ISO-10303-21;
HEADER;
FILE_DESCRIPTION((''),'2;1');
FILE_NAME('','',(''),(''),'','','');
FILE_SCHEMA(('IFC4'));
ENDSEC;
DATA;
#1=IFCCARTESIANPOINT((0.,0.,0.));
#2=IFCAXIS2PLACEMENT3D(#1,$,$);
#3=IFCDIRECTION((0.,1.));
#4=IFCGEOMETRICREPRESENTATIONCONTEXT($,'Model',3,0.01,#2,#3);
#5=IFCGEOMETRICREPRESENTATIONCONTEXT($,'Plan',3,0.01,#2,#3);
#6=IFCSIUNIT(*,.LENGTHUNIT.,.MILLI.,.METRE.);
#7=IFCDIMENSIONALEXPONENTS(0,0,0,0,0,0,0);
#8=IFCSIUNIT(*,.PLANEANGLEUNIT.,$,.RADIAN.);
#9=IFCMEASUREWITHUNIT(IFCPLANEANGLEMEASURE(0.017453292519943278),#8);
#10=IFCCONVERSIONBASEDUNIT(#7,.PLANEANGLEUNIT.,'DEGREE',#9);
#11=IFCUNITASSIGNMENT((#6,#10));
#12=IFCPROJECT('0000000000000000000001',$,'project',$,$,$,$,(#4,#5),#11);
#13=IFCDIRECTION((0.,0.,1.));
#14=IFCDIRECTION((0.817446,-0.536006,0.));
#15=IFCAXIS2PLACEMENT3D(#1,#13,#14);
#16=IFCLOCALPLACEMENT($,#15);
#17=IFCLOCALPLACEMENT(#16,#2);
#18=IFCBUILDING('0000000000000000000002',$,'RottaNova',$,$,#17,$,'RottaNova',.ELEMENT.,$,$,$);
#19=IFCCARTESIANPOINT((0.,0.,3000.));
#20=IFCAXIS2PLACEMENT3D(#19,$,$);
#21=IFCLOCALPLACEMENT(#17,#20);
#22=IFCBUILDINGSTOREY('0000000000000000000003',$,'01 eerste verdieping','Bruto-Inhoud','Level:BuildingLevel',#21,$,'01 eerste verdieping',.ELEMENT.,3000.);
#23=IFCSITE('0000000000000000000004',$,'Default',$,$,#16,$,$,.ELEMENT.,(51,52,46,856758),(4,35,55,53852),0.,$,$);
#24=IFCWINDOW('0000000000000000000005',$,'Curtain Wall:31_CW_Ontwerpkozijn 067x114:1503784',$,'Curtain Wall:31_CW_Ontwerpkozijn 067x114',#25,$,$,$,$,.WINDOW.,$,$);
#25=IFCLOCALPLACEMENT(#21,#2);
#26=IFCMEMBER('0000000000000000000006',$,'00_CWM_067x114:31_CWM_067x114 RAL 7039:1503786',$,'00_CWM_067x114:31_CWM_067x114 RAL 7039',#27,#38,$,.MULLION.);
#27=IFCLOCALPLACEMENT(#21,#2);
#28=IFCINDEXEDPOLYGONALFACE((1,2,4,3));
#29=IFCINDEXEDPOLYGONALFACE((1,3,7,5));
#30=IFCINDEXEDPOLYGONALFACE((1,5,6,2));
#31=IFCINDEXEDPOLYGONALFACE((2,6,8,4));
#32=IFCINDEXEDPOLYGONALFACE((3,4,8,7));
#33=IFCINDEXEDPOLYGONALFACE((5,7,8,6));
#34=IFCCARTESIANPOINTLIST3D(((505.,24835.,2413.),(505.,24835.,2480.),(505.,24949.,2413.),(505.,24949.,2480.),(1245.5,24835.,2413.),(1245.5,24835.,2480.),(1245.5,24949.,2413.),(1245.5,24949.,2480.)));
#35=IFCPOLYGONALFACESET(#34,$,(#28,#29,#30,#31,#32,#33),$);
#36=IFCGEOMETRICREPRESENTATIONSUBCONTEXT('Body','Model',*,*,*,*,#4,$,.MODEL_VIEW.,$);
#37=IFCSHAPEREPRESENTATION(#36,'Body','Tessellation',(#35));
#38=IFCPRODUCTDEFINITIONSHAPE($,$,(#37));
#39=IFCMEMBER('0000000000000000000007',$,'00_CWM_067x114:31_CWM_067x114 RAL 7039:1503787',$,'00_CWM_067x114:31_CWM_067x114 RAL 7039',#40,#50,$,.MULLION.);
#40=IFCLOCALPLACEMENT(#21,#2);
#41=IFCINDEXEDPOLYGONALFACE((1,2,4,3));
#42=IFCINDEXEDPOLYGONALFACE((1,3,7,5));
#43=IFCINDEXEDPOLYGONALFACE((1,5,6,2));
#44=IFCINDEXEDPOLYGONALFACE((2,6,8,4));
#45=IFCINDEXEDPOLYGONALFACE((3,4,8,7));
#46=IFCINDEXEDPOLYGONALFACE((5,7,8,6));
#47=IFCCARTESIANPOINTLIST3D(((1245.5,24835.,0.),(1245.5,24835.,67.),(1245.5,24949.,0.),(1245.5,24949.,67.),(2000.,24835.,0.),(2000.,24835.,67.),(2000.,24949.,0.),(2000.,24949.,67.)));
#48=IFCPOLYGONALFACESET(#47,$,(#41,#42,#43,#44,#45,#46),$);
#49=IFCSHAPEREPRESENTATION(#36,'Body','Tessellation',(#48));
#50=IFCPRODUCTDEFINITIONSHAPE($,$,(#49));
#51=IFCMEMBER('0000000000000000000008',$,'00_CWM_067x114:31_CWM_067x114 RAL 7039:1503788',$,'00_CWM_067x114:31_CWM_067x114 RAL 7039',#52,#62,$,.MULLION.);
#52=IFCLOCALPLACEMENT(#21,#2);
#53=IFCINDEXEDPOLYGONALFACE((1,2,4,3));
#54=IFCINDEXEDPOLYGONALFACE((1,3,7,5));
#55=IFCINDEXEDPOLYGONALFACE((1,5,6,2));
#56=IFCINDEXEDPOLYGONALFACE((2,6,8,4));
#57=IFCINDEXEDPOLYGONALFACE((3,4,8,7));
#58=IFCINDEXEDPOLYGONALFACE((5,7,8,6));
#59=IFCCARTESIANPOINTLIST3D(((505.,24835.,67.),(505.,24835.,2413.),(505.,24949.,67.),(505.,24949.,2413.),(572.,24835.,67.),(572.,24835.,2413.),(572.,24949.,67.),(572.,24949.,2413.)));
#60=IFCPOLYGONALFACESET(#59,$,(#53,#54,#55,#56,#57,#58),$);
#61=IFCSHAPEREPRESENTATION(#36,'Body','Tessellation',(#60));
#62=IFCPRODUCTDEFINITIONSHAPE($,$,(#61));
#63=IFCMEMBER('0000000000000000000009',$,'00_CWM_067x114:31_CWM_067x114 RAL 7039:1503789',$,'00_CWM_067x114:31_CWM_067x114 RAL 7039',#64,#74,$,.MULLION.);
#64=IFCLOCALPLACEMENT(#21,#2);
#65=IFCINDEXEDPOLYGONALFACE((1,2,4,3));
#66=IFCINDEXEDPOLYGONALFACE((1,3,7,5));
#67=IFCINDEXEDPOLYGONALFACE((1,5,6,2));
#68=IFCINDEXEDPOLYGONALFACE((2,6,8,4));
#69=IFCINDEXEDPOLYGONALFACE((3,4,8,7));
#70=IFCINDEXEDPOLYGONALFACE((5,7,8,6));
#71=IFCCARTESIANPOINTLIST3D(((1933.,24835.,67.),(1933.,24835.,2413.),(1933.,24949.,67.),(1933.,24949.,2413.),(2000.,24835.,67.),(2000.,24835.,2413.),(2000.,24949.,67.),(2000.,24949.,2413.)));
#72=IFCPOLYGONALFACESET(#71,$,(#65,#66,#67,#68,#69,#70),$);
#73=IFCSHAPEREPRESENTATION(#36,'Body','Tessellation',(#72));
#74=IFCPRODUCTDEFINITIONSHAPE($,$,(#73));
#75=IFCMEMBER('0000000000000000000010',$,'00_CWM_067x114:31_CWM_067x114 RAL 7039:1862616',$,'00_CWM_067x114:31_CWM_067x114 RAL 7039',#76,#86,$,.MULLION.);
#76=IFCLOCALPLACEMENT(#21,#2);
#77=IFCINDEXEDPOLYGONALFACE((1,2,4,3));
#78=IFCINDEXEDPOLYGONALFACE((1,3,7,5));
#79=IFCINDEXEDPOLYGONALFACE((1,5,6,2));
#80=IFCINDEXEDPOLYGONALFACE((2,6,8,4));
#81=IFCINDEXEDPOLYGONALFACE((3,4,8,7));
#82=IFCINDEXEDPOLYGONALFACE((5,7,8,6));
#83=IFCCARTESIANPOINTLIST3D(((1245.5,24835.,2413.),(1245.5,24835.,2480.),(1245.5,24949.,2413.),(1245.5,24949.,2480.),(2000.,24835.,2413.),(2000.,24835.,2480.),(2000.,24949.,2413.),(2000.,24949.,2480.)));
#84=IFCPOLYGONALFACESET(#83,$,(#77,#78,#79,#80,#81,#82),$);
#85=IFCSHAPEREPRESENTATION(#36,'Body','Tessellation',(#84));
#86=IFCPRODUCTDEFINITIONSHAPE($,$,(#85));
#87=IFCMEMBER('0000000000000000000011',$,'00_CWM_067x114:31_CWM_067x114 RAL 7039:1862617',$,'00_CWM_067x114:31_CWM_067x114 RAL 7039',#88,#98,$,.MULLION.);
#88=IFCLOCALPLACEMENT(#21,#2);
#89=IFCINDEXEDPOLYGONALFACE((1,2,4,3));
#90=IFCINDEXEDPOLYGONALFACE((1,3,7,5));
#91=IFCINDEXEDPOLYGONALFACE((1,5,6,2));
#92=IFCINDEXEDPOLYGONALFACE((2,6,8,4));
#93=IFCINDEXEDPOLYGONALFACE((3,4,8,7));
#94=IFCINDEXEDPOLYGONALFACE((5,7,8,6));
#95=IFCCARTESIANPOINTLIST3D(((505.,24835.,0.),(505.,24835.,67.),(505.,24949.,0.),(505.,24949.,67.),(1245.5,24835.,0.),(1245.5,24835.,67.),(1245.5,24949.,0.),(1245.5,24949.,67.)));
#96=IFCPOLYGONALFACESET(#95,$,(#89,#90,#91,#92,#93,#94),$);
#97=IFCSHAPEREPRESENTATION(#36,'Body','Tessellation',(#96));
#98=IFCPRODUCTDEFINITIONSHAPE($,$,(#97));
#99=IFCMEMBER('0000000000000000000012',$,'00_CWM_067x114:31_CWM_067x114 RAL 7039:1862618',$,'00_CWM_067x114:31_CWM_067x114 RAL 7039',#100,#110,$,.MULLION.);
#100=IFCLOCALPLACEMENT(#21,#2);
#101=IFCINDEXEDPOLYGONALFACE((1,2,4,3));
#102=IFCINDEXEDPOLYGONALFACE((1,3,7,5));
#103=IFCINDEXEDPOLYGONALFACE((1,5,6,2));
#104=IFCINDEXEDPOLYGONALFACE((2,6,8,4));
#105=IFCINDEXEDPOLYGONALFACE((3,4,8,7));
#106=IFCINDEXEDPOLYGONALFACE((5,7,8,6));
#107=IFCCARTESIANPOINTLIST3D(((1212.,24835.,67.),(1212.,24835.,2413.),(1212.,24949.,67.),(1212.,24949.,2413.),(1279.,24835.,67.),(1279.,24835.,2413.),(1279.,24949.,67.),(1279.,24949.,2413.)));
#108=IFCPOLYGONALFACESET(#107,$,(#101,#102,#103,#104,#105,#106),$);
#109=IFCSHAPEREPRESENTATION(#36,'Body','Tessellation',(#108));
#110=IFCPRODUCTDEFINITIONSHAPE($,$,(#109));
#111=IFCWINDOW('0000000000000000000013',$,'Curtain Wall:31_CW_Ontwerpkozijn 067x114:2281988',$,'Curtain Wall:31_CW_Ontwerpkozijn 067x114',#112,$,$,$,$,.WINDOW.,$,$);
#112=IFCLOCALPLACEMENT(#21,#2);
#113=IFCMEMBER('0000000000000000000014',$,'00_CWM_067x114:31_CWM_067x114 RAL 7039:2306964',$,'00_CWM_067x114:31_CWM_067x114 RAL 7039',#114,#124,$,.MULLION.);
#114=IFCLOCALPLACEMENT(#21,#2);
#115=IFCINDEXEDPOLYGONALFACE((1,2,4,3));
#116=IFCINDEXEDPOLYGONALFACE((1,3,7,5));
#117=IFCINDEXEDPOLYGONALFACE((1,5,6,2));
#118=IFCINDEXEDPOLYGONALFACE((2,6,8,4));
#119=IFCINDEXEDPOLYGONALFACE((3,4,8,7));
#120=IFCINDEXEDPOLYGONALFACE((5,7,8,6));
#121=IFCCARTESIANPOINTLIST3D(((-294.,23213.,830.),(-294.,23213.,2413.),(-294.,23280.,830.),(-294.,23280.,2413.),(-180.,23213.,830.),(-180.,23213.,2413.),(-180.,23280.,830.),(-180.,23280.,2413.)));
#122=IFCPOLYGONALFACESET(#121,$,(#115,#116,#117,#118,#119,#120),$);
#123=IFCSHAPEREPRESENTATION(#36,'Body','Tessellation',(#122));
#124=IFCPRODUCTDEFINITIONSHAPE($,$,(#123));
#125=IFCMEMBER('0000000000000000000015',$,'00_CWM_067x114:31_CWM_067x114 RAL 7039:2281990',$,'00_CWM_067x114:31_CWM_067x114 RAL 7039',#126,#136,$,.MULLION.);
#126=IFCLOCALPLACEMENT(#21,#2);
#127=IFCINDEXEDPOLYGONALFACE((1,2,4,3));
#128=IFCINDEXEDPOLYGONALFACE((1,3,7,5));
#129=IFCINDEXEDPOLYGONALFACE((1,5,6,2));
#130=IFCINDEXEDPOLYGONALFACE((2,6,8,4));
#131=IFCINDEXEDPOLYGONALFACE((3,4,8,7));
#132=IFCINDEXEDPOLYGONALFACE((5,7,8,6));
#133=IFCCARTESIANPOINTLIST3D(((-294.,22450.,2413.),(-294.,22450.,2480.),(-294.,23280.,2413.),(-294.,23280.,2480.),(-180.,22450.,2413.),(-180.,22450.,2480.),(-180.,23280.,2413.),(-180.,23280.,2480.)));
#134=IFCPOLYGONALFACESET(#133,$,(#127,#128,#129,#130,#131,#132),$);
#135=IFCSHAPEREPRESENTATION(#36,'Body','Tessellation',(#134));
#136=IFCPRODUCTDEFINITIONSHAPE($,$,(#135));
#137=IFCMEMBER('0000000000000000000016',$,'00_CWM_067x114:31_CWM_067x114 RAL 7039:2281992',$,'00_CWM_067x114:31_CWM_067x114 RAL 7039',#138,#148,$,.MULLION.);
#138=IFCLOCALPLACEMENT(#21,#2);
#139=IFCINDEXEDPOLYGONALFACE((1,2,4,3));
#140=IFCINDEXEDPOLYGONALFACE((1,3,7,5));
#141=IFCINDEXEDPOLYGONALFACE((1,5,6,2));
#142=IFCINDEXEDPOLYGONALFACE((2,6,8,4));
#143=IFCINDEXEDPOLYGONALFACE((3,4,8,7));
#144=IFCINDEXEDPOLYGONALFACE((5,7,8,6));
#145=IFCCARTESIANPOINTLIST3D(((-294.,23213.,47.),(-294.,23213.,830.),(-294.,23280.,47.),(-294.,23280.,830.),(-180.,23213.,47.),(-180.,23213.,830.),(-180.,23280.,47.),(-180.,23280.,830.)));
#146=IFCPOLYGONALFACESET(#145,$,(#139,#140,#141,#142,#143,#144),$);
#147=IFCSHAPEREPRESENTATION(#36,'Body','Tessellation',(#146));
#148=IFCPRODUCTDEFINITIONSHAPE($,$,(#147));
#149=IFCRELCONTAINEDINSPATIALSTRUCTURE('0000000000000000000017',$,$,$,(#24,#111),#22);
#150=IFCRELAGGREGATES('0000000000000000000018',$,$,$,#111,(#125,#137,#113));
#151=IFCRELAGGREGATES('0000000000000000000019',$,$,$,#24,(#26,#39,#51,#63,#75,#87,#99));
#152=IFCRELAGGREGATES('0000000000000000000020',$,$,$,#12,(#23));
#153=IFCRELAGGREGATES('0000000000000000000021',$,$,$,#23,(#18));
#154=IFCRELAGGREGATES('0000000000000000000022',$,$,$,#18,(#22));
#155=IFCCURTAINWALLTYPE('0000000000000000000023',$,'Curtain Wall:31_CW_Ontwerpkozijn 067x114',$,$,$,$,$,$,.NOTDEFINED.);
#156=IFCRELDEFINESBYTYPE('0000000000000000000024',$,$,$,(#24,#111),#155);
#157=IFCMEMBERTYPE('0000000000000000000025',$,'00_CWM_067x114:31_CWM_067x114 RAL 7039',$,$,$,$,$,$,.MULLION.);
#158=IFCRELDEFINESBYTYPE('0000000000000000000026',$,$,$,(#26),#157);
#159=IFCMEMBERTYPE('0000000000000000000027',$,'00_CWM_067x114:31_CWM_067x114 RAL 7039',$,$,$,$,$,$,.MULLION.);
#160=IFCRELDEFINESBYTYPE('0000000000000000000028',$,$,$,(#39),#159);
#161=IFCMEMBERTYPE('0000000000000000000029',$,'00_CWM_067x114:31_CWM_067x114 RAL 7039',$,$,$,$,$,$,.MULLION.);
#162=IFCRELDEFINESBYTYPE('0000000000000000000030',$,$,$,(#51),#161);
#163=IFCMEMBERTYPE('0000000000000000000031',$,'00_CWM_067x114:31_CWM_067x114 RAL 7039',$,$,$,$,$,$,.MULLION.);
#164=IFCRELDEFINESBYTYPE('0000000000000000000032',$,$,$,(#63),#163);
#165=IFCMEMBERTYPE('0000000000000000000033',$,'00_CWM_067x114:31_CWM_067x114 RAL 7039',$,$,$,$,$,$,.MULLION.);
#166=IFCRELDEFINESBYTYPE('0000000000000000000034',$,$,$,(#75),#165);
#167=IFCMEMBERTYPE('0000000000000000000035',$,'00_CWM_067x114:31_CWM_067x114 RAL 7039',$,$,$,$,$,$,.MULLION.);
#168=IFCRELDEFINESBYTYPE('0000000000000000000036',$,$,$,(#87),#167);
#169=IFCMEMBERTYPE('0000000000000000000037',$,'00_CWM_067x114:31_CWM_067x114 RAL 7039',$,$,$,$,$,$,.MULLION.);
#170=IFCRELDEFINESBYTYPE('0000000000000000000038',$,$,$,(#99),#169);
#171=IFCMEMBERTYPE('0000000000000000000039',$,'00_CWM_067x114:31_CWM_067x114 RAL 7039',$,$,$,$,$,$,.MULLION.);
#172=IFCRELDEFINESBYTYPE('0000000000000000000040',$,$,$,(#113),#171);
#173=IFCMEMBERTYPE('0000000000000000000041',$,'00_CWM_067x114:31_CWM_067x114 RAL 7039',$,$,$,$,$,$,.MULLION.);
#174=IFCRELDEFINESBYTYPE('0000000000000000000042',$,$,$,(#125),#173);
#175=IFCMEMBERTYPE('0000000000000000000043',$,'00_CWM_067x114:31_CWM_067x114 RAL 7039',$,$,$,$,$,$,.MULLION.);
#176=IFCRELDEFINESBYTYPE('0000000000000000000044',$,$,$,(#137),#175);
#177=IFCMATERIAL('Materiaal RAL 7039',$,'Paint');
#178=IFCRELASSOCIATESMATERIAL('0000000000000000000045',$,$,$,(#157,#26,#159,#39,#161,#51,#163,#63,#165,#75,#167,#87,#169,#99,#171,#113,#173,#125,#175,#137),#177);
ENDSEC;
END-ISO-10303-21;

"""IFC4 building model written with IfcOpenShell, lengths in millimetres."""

from ifc_helpers import new_model, entity, si_unit, converted_unit, direction, frame, origin, place, context, subcontext, project, spatial, indexed_curve, outline, extrude, source, transform, mapped, material, type_object, type_shapes, element, aggregate, save


model = new_model("IFC4")

# Units and contexts
model_context = context("Model", 3, precision=0.01, world=origin(), true_north=direction((0.0, 1.0)))
plan_context = context("Plan", 3, precision=0.01, world=origin(), true_north=direction((0.0, 1.0)))
body_context = subcontext(model_context, "Body", "Model", "MODEL_VIEW")
ifc_project = project(units=[si_unit("LENGTHUNIT", "METRE", prefix="MILLI"), converted_unit("PLANEANGLEUNIT", "DEGREE", entity("IfcPlaneAngleMeasure", 0.017453292519943278), si_unit("PLANEANGLEUNIT", "RADIAN"), dimensions=[0, 0, 0, 0, 0, 0, 0])], contexts=[model_context, plan_context])

# Site, building, storey
site_placement = place(None, frame((0.0, 0.0, 0.0), z_axis=(0.0, 0.0, 1.0), x_axis=(0.817446, -0.536006, 0.0)))
site = spatial("IfcSite", under=ifc_project, at=site_placement, Name="Default", CompositionType="ELEMENT", RefLatitude=(51, 52, 46, 856758), RefLongitude=(4, 35, 55, 53852), RefElevation=0.0)
building_placement = place(site_placement, origin())
building = spatial("IfcBuilding", under=site, at=building_placement, Name="RottaNova", LongName="RottaNova", CompositionType="ELEMENT")
storey_placement = place(building_placement, frame((0.0, 0.0, 3000.0)))
storey = spatial("IfcBuildingStorey", under=building, at=storey_placement, Name="01 eerste verdieping", Description="Bruto-Inhoud", ObjectType="Level:BuildingLevel", LongName="01 eerste verdieping", CompositionType="ELEMENT", Elevation=3000.0)

# Windows, members
curtain_wall_type = type_object("IfcCurtainWallType", Name="Curtain Wall:31_CW_Ontwerpkozijn 067x114", PredefinedType="NOTDEFINED")
window_1_placement = place(storey_placement, frame((0.0, 0.0, -3000.0)))
window_1 = element("IfcWindow", 1, at=window_1_placement, inside=storey, type_object=curtain_wall_type, Name="Curtain Wall:31_CW_Ontwerpkozijn 067x114:1503784", ObjectType="Curtain Wall:31_CW_Ontwerpkozijn 067x114", PredefinedType="WINDOW")
ifc_material_1 = material(Name="Materiaal RAL 7039", Category="Paint")
member_type_1 = type_object("IfcMemberType", Name="00_CWM_067x114:31_CWM_067x114 RAL 7039", PredefinedType="MULLION", material=ifc_material_1)
shared_shape_1 = source(origin(), body_context, "Body", "SweptSolid", [
    extrude(outline(indexed_curve([(-33.5, -57.0), (33.5, -57.0), (33.5, 57.0), (-33.5, 57.0), (-33.5, -57.0)], self_intersect=False)), frame((-33.5, 57.0, -740.5), z_axis=(0.0, 0.0, 1.0), x_axis=(-1.0, 0.0, 0.0)), (0.0, 0.0, 1.0), 740.5),
])
type_shapes(member_type_1, [shared_shape_1])
member_1_placement = place(window_1_placement, frame((505.0, 24835.0, 5480.0), z_axis=(-1.0, 0.0, 0.0), x_axis=(0.0, 0.0, 1.0)))
member_1 = element("IfcMember", 2, at=member_1_placement, type_object=member_type_1, material=ifc_material_1, Name="00_CWM_067x114:31_CWM_067x114 RAL 7039:1503786", ObjectType="00_CWM_067x114:31_CWM_067x114 RAL 7039", PredefinedType="MULLION", context=body_context, shape_type="MappedRepresentation", body=[
    mapped(shared_shape_1, transform((0.0, 0.0, 0.0), scale=1.0)),
])
member_type_2 = type_object("IfcMemberType", Name="00_CWM_067x114:31_CWM_067x114 RAL 7039", PredefinedType="MULLION", material=ifc_material_1)
shared_shape_2 = source(origin(), body_context, "Body", "SweptSolid", [
    extrude(outline(indexed_curve([(-33.5, -57.0), (33.5, -57.0), (33.5, 57.0), (-33.5, 57.0), (-33.5, -57.0)], self_intersect=False)), frame((-33.5, 57.0, -754.5), z_axis=(0.0, 0.0, 1.0), x_axis=(-1.0, 0.0, 0.0)), (0.0, 0.0, 1.0), 754.5),
])
type_shapes(member_type_2, [shared_shape_2])
member_2_placement = place(window_1_placement, frame((2000.0, 24835.0, 3000.0), z_axis=(1.0, 0.0, 0.0), x_axis=(0.0, 0.0, -1.0)))
member_2 = element("IfcMember", 3, at=member_2_placement, type_object=member_type_2, material=ifc_material_1, Name="00_CWM_067x114:31_CWM_067x114 RAL 7039:1503787", ObjectType="00_CWM_067x114:31_CWM_067x114 RAL 7039", PredefinedType="MULLION", context=body_context, shape_type="MappedRepresentation", body=[
    mapped(shared_shape_2, transform((0.0, 0.0, 0.0), scale=1.0)),
])
member_type_3 = type_object("IfcMemberType", Name="00_CWM_067x114:31_CWM_067x114 RAL 7039", PredefinedType="MULLION", material=ifc_material_1)
shared_shape_3 = source(origin(), body_context, "Body", "SweptSolid", [
    extrude(outline(indexed_curve([(-33.5, -57.0), (33.5, -57.0), (33.5, 57.0), (-33.5, 57.0), (-33.5, -57.0)], self_intersect=False)), frame((-33.5, 57.0, -2346.0), z_axis=(0.0, 0.0, 1.0), x_axis=(-1.0, 0.0, 0.0)), (0.0, 0.0, 1.0), 2346.0),
])
type_shapes(member_type_3, [shared_shape_3])
member_3_placement = place(window_1_placement, frame((505.0, 24835.0, 3067.0), z_axis=(0.0, 0.0, -1.0), x_axis=(-1.0, 0.0, 0.0)))
member_3 = element("IfcMember", 4, at=member_3_placement, type_object=member_type_3, material=ifc_material_1, Name="00_CWM_067x114:31_CWM_067x114 RAL 7039:1503788", ObjectType="00_CWM_067x114:31_CWM_067x114 RAL 7039", PredefinedType="MULLION", context=body_context, shape_type="MappedRepresentation", body=[
    mapped(shared_shape_3, transform((0.0, 0.0, 0.0), scale=1.0)),
])
member_type_4 = type_object("IfcMemberType", Name="00_CWM_067x114:31_CWM_067x114 RAL 7039", PredefinedType="MULLION", material=ifc_material_1)
shared_shape_4 = source(origin(), body_context, "Body", "SweptSolid", [
    extrude(outline(indexed_curve([(-33.5, -57.0), (33.5, -57.0), (33.5, 57.0), (-33.5, 57.0), (-33.5, -57.0)], self_intersect=False)), frame((-33.5, 57.0, -2346.0), z_axis=(0.0, 0.0, 1.0), x_axis=(-1.0, 0.0, 0.0)), (0.0, 0.0, 1.0), 2346.0),
])
type_shapes(member_type_4, [shared_shape_4])
member_4_placement = place(window_1_placement, frame((2000.0, 24835.0, 5413.0)))
member_4 = element("IfcMember", 5, at=member_4_placement, type_object=member_type_4, material=ifc_material_1, Name="00_CWM_067x114:31_CWM_067x114 RAL 7039:1503789", ObjectType="00_CWM_067x114:31_CWM_067x114 RAL 7039", PredefinedType="MULLION", context=body_context, shape_type="MappedRepresentation", body=[
    mapped(shared_shape_4, transform((0.0, 0.0, 0.0), scale=1.0)),
])
member_type_5 = type_object("IfcMemberType", Name="00_CWM_067x114:31_CWM_067x114 RAL 7039", PredefinedType="MULLION", material=ifc_material_1)
shared_shape_5 = source(origin(), body_context, "Body", "SweptSolid", [
    extrude(outline(indexed_curve([(-33.5, -57.0), (33.5, -57.0), (33.5, 57.0), (-33.5, 57.0), (-33.5, -57.0)], self_intersect=False)), frame((-33.5, 57.0, -754.5), z_axis=(0.0, 0.0, 1.0), x_axis=(-1.0, 0.0, 0.0)), (0.0, 0.0, 1.0), 754.5),
])
type_shapes(member_type_5, [shared_shape_5])
member_5_placement = place(window_1_placement, frame((1245.5, 24835.0, 5480.0), z_axis=(-1.0, 0.0, 0.0), x_axis=(0.0, 0.0, 1.0)))
member_5 = element("IfcMember", 6, at=member_5_placement, type_object=member_type_5, material=ifc_material_1, Name="00_CWM_067x114:31_CWM_067x114 RAL 7039:1862616", ObjectType="00_CWM_067x114:31_CWM_067x114 RAL 7039", PredefinedType="MULLION", context=body_context, shape_type="MappedRepresentation", body=[
    mapped(shared_shape_5, transform((0.0, 0.0, 0.0), scale=1.0)),
])
member_type_6 = type_object("IfcMemberType", Name="00_CWM_067x114:31_CWM_067x114 RAL 7039", PredefinedType="MULLION", material=ifc_material_1)
shared_shape_6 = source(origin(), body_context, "Body", "SweptSolid", [
    extrude(outline(indexed_curve([(-33.5, -57.0), (33.5, -57.0), (33.5, 57.0), (-33.5, 57.0), (-33.5, -57.0)], self_intersect=False)), frame((-33.5, 57.0, -740.5), z_axis=(0.0, 0.0, 1.0), x_axis=(-1.0, 0.0, 0.0)), (0.0, 0.0, 1.0), 740.5),
])
type_shapes(member_type_6, [shared_shape_6])
member_6_placement = place(window_1_placement, frame((1245.5, 24835.0, 3000.0), z_axis=(1.0, 0.0, 0.0), x_axis=(0.0, 0.0, -1.0)))
member_6 = element("IfcMember", 7, at=member_6_placement, type_object=member_type_6, material=ifc_material_1, Name="00_CWM_067x114:31_CWM_067x114 RAL 7039:1862617", ObjectType="00_CWM_067x114:31_CWM_067x114 RAL 7039", PredefinedType="MULLION", context=body_context, shape_type="MappedRepresentation", body=[
    mapped(shared_shape_6, transform((0.0, 0.0, 0.0), scale=1.0)),
])
member_type_7 = type_object("IfcMemberType", Name="00_CWM_067x114:31_CWM_067x114 RAL 7039", PredefinedType="MULLION", material=ifc_material_1)
shared_shape_7 = source(origin(), body_context, "Body", "SweptSolid", [
    extrude(outline(indexed_curve([(-33.5, -57.0), (33.5, -57.0), (33.5, 57.0), (-33.5, 57.0), (-33.5, -57.0)], self_intersect=False)), frame((0.0, 57.0, -2346.0), z_axis=(0.0, 0.0, 1.0), x_axis=(-1.0, 0.0, 0.0)), (0.0, 0.0, 1.0), 2346.0),
])
type_shapes(member_type_7, [shared_shape_7])
member_7_placement = place(window_1_placement, frame((1245.5, 24835.0, 3067.0), z_axis=(0.0, 0.0, -1.0), x_axis=(-1.0, 0.0, 0.0)))
member_7 = element("IfcMember", 8, at=member_7_placement, type_object=member_type_7, material=ifc_material_1, Name="00_CWM_067x114:31_CWM_067x114 RAL 7039:1862618", ObjectType="00_CWM_067x114:31_CWM_067x114 RAL 7039", PredefinedType="MULLION", context=body_context, shape_type="MappedRepresentation", body=[
    mapped(shared_shape_7, transform((0.0, 0.0, 0.0), scale=1.0)),
])
window_2_placement = place(storey_placement, frame((0.0, 0.0, -3000.0)))
window_2 = element("IfcWindow", 9, at=window_2_placement, inside=storey, type_object=curtain_wall_type, Name="Curtain Wall:31_CW_Ontwerpkozijn 067x114:2281988", ObjectType="Curtain Wall:31_CW_Ontwerpkozijn 067x114", PredefinedType="WINDOW")
member_type_8 = type_object("IfcMemberType", Name="00_CWM_067x114:31_CWM_067x114 RAL 7039", PredefinedType="MULLION", material=ifc_material_1)
shared_shape_8 = source(origin(), body_context, "Body", "SweptSolid", [
    extrude(outline(indexed_curve([(-33.5, -57.0), (33.5, -57.0), (33.5, 57.0), (-33.5, 57.0), (-33.5, -57.0)], self_intersect=False)), frame((-33.5, -57.0, -1583.0), z_axis=(0.0, 0.0, 1.0), x_axis=(-1.0, 0.0, 0.0)), (0.0, 0.0, 1.0), 1583.0),
])
type_shapes(member_type_8, [shared_shape_8])
member_8_placement = place(window_2_placement, frame((-180.0, 23280.0, 3830.0), z_axis=(0.0, 0.0, -1.0), x_axis=(0.0, 1.0, 0.0)))
member_8 = element("IfcMember", 10, at=member_8_placement, type_object=member_type_8, material=ifc_material_1, Name="00_CWM_067x114:31_CWM_067x114 RAL 7039:2306964", ObjectType="00_CWM_067x114:31_CWM_067x114 RAL 7039", PredefinedType="MULLION", context=body_context, shape_type="MappedRepresentation", body=[
    mapped(shared_shape_8, transform((0.0, 0.0, 0.0), scale=1.0)),
])
member_type_9 = type_object("IfcMemberType", Name="00_CWM_067x114:31_CWM_067x114 RAL 7039", PredefinedType="MULLION", material=ifc_material_1)
shared_shape_9 = source(origin(), body_context, "Body", "SweptSolid", [
    extrude(outline(indexed_curve([(-33.5, -57.0), (33.5, -57.0), (33.5, 57.0), (-33.5, 57.0), (-33.5, -57.0)], self_intersect=False)), frame((-33.5, -57.0, -830.0), z_axis=(0.0, 0.0, 1.0), x_axis=(-1.0, 0.0, 0.0)), (0.0, 0.0, 1.0), 830.0),
])
type_shapes(member_type_9, [shared_shape_9])
member_9_placement = place(window_2_placement, frame((-180.0, 23280.0, 5480.0), z_axis=(0.0, 1.0, 0.0), x_axis=(0.0, 0.0, 1.0)))
member_9 = element("IfcMember", 11, at=member_9_placement, type_object=member_type_9, material=ifc_material_1, Name="00_CWM_067x114:31_CWM_067x114 RAL 7039:2281990", ObjectType="00_CWM_067x114:31_CWM_067x114 RAL 7039", PredefinedType="MULLION", context=body_context, shape_type="MappedRepresentation", body=[
    mapped(shared_shape_9, transform((0.0, 0.0, 0.0), scale=1.0)),
])
member_type_10 = type_object("IfcMemberType", Name="00_CWM_067x114:31_CWM_067x114 RAL 7039", PredefinedType="MULLION", material=ifc_material_1)
shared_shape_10 = source(origin(), body_context, "Body", "SweptSolid", [
    extrude(outline(indexed_curve([(-33.5, -57.0), (33.5, -57.0), (33.5, 57.0), (-33.5, 57.0), (-33.5, -57.0)], self_intersect=False)), frame((-33.5, -57.0, -783.0), z_axis=(0.0, 0.0, 1.0), x_axis=(-1.0, 0.0, 0.0)), (0.0, 0.0, 1.0), 783.0),
])
type_shapes(member_type_10, [shared_shape_10])
member_10_placement = place(window_2_placement, frame((-180.0, 23280.0, 3047.0), z_axis=(0.0, 0.0, -1.0), x_axis=(0.0, 1.0, 0.0)))
member_10 = element("IfcMember", 12, at=member_10_placement, type_object=member_type_10, material=ifc_material_1, Name="00_CWM_067x114:31_CWM_067x114 RAL 7039:2281992", ObjectType="00_CWM_067x114:31_CWM_067x114 RAL 7039", PredefinedType="MULLION", context=body_context, shape_type="MappedRepresentation", body=[
    mapped(shared_shape_10, transform((0.0, 0.0, 0.0), scale=1.0)),
])
aggregate(window_2, [member_9, member_10, member_8])

aggregate(window_1, [member_1, member_2, member_3, member_4, member_5, member_6, member_7])

save(model, "model.ifc")
